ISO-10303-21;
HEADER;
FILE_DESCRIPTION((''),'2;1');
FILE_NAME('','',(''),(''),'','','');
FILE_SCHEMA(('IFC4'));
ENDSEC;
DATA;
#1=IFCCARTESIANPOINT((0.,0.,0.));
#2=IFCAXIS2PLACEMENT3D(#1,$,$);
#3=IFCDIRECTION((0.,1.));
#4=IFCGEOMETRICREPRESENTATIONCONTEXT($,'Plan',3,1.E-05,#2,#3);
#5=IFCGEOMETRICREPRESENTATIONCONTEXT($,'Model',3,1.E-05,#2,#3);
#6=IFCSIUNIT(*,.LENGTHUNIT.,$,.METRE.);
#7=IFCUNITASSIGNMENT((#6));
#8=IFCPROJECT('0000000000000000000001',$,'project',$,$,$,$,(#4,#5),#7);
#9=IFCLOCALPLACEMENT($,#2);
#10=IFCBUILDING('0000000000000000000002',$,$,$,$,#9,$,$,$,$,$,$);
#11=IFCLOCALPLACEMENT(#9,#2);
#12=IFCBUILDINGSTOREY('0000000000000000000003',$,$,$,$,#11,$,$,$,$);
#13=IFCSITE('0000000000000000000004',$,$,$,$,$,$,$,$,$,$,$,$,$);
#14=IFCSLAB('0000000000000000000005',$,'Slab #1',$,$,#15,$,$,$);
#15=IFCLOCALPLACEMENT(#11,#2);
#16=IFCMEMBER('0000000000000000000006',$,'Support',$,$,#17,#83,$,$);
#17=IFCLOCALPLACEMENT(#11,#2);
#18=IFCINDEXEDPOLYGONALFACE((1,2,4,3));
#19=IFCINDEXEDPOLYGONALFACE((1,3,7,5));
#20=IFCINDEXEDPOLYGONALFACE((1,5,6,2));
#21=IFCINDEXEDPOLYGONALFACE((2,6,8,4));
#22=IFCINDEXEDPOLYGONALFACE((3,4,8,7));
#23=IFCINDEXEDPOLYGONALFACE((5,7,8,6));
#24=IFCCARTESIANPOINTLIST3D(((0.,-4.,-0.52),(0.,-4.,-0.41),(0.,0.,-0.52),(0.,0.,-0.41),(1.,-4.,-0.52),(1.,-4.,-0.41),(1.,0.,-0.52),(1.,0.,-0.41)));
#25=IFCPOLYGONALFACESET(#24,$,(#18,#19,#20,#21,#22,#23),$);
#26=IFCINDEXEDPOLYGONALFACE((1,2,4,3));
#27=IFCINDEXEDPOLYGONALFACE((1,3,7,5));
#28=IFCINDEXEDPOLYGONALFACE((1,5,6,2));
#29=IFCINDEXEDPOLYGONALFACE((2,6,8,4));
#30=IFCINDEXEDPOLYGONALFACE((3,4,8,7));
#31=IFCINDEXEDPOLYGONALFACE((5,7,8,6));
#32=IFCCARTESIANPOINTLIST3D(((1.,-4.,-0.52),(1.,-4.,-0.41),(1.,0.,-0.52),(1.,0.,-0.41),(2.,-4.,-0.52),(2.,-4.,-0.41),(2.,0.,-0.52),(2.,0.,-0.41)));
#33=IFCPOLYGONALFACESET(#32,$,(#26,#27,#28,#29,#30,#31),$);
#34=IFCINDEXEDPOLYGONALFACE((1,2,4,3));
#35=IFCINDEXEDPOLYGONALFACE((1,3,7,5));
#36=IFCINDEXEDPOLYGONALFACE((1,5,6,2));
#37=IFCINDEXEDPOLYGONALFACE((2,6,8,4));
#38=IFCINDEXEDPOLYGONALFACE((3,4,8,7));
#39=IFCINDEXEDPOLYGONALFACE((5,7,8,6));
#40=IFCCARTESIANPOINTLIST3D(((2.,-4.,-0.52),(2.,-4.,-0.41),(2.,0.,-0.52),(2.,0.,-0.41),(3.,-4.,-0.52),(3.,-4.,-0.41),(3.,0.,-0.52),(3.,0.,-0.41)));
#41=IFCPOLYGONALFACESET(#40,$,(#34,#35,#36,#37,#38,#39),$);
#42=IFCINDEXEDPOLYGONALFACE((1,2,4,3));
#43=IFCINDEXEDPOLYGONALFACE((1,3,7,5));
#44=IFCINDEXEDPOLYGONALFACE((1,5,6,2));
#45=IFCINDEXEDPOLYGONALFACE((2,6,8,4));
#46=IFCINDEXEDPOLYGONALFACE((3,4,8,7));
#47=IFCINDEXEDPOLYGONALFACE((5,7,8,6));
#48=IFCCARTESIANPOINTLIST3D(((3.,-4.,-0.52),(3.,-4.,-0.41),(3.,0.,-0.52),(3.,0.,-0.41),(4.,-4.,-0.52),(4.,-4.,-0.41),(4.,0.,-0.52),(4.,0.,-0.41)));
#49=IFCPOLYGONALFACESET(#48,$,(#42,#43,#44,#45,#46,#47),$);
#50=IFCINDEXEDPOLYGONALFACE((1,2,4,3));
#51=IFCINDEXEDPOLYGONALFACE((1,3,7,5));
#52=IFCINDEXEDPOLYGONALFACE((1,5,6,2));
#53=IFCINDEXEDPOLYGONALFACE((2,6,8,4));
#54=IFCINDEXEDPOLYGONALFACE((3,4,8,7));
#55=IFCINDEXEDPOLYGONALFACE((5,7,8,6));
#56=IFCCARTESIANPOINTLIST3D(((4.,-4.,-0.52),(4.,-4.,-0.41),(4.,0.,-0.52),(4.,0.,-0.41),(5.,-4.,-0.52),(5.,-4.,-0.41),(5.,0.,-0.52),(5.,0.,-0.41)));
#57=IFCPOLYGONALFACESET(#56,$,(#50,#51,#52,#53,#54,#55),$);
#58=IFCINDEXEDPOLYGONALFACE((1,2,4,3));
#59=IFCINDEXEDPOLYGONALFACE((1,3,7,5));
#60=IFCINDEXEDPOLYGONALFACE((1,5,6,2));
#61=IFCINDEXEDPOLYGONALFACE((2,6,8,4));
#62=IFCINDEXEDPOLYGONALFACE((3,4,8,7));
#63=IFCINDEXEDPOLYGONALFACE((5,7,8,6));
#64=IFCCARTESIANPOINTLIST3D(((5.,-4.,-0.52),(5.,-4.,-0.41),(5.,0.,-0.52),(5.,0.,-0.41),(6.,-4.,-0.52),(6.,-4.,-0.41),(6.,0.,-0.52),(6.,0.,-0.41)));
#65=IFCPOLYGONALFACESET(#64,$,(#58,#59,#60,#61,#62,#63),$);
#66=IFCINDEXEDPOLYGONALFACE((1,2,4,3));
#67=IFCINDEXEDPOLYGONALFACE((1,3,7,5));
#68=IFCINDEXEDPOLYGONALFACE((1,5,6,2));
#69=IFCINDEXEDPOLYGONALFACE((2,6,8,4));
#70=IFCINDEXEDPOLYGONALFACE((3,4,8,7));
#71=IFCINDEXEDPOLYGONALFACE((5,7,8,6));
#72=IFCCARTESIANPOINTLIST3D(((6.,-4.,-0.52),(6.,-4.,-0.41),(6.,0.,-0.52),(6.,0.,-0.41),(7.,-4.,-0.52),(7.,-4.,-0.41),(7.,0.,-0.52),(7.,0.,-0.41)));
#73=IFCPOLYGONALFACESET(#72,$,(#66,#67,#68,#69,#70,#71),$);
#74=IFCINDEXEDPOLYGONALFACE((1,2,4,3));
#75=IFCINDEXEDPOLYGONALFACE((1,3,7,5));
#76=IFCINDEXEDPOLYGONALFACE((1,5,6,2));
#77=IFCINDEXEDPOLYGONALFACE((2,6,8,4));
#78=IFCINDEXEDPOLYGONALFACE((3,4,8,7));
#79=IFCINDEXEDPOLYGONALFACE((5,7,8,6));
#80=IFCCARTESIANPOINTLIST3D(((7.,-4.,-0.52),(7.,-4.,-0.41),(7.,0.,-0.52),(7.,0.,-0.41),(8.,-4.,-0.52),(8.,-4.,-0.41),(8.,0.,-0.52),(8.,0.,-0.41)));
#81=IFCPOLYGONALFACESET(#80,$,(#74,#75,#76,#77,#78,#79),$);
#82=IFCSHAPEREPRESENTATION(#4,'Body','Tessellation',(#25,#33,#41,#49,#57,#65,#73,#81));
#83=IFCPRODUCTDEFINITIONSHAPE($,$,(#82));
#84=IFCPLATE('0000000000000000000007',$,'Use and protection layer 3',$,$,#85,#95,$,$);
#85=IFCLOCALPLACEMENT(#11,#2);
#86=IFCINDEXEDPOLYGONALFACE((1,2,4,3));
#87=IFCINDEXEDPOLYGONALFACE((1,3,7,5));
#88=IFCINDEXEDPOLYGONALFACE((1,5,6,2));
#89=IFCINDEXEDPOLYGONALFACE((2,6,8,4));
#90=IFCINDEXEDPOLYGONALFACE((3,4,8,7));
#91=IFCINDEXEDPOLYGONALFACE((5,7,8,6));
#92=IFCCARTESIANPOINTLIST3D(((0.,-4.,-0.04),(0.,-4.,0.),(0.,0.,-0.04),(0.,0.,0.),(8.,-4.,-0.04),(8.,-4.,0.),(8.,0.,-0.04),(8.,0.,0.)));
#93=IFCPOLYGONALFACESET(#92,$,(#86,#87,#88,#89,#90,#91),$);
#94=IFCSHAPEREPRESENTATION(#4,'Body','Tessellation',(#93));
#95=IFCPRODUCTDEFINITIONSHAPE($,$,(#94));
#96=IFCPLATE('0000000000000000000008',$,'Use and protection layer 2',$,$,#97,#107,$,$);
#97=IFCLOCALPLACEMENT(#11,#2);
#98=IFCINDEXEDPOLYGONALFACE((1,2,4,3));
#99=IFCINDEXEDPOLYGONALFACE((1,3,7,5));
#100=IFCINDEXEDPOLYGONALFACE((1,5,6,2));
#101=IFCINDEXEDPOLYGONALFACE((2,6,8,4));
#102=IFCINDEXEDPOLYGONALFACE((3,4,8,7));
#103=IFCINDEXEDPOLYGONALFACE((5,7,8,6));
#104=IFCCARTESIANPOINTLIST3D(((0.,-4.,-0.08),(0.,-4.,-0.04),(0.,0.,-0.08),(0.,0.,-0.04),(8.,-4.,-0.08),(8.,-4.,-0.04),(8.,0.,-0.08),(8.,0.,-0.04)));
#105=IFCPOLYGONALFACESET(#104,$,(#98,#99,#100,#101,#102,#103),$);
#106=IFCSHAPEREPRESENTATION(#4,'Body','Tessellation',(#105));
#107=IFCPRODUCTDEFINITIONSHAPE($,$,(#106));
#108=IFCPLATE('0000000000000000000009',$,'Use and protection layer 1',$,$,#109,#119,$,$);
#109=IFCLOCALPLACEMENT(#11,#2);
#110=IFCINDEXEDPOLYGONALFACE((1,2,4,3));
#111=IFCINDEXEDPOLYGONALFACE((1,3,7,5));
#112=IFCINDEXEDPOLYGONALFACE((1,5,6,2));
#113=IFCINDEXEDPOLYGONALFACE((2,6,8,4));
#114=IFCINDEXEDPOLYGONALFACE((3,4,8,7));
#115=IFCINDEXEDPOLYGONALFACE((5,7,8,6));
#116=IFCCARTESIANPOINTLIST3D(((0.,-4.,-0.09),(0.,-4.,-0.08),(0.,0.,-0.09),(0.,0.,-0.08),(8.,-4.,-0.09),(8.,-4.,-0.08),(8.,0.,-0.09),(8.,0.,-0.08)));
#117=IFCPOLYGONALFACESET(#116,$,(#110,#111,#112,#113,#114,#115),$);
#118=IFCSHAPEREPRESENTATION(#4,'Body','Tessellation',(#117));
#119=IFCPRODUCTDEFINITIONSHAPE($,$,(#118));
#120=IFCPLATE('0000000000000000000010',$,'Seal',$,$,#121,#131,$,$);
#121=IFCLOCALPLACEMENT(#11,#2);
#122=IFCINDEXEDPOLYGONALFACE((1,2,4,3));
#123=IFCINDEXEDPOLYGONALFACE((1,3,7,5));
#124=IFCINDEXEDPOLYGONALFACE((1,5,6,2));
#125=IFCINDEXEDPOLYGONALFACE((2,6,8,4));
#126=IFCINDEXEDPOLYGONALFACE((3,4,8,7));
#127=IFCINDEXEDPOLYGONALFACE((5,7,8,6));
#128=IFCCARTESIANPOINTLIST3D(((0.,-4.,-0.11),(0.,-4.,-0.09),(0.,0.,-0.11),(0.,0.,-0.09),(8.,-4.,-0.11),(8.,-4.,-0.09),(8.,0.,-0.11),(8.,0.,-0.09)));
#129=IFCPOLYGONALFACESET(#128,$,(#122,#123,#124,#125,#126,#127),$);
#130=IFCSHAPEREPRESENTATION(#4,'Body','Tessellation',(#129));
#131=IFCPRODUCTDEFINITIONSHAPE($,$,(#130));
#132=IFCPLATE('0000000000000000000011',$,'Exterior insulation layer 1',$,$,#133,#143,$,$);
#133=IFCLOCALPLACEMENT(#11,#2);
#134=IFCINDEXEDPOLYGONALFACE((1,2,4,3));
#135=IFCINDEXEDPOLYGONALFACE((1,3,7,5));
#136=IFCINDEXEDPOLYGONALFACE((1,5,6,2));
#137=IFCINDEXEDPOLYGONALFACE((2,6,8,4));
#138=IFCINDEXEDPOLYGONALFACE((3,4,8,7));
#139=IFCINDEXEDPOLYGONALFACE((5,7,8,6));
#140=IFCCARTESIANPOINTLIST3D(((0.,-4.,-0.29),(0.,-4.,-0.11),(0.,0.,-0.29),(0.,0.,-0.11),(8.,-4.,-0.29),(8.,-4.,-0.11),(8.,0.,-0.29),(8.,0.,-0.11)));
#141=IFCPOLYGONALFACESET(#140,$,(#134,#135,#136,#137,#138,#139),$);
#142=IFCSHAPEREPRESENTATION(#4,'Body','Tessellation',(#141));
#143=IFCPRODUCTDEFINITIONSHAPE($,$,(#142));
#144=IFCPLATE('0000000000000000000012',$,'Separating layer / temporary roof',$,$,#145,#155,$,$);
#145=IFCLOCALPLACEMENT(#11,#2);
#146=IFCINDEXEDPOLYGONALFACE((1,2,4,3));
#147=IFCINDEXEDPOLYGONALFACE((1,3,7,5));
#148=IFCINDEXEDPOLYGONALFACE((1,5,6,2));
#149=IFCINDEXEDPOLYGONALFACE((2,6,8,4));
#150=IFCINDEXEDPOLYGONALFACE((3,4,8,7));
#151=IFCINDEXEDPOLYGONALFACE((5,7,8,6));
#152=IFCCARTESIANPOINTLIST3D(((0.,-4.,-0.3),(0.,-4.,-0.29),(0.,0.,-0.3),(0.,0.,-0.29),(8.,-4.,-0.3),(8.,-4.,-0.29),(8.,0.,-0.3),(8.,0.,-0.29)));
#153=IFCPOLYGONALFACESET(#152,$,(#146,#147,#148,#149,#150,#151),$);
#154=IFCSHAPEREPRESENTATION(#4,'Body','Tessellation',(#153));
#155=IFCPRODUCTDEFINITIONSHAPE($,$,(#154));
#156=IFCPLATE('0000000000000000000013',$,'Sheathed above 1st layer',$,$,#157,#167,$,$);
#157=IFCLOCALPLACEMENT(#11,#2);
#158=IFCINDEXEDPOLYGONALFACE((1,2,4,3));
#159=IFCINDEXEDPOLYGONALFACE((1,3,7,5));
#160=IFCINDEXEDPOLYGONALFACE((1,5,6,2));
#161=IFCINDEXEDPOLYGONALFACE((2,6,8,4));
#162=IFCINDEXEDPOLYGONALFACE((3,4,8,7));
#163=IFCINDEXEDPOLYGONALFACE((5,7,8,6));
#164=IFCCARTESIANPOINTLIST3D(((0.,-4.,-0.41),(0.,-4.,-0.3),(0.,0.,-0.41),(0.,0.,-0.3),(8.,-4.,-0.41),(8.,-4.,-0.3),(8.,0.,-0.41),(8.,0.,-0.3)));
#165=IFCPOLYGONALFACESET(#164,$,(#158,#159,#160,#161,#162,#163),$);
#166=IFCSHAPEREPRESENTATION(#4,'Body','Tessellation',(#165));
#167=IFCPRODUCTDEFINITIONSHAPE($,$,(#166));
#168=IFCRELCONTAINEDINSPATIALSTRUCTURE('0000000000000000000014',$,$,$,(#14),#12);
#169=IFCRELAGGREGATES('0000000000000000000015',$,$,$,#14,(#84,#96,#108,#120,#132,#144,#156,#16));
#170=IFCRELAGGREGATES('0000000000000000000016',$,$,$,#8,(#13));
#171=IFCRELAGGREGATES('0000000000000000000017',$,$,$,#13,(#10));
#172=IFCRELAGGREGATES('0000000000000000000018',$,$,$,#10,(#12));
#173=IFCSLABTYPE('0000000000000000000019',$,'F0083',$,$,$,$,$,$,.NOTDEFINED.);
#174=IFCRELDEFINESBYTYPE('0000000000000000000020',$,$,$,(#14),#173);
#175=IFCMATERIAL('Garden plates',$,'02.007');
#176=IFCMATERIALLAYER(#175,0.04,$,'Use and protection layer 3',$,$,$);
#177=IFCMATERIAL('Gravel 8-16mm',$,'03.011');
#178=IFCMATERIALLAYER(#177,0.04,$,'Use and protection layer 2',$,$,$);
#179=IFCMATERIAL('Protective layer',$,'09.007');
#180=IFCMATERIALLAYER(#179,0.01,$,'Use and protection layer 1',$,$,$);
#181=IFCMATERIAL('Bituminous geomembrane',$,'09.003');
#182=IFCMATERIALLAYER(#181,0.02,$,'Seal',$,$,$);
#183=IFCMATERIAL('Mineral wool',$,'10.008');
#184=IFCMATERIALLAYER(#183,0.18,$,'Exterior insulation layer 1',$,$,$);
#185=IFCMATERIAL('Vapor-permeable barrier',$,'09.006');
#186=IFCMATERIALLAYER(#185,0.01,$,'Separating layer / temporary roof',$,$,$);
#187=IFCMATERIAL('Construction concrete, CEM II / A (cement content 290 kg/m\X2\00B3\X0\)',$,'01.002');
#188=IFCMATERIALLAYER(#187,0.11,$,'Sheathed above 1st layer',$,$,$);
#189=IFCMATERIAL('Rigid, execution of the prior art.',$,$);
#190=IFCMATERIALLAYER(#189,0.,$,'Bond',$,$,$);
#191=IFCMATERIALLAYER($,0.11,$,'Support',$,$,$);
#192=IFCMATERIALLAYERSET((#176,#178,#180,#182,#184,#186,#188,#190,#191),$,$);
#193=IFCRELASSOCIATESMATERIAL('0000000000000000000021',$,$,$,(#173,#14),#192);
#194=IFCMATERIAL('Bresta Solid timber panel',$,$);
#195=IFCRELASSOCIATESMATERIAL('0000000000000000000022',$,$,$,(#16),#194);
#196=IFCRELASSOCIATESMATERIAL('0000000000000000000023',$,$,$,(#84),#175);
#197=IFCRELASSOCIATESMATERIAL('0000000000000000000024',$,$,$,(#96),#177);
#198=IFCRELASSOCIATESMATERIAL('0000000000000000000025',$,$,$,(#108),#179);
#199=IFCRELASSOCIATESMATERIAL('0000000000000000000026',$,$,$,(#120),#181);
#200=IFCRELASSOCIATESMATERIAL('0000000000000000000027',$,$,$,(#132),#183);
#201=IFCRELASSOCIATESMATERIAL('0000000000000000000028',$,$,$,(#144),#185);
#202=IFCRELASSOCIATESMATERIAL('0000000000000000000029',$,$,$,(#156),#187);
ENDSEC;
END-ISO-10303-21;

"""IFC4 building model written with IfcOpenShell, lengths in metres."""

from ifc_helpers import new_model, si_unit, direction, frame, frame_2d, origin, origin_with_axes, place, context, project, spatial, rectangle, extrude, material, layer, layer_set, type_object, element, aggregate, save


model = new_model("IFC4")

# Units and contexts
plan_context = context("Plan", 3, precision=1e-05, world=origin(), true_north=direction((0.0, 1.0)))
model_context = context("Model", 3, precision=1e-05, world=origin(), true_north=direction((0.0, 1.0)))
ifc_project = project(units=[si_unit("LENGTHUNIT", "METRE")], contexts=[plan_context, model_context])

# Site, building, storey
site = spatial("IfcSite", under=ifc_project)
building_placement = place(None, origin())
building = spatial("IfcBuilding", under=site, at=building_placement)
storey_placement = place(building_placement, origin())
storey = spatial("IfcBuildingStorey", under=building, at=storey_placement)

# Slab, member, plates
ifc_material_1 = material(Name="Garden plates", Category="02.007")
ifc_layer_1 = layer(ifc_material_1, 0.04, Name="Use and protection layer 3")
ifc_material_2 = material(Name="Gravel 8-16mm", Category="03.011")
ifc_layer_2 = layer(ifc_material_2, 0.04, Name="Use and protection layer 2")
ifc_material_3 = material(Name="Protective layer", Category="09.007")
ifc_layer_3 = layer(ifc_material_3, 0.01, Name="Use and protection layer 1")
ifc_material_4 = material(Name="Bituminous geomembrane", Category="09.003")
ifc_layer_4 = layer(ifc_material_4, 0.02, Name="Seal")
ifc_material_5 = material(Name="Mineral wool", Category="10.008")
ifc_layer_5 = layer(ifc_material_5, 0.18, Name="Exterior insulation layer 1")
ifc_material_6 = material(Name="Vapor-permeable barrier", Category="09.006")
ifc_layer_6 = layer(ifc_material_6, 0.01, Name="Separating layer / temporary roof")
ifc_material_7 = material(Name="Construction concrete, CEM II / A (cement content 290 kg/m³)", Category="01.002")
ifc_layer_7 = layer(ifc_material_7, 0.11, Name="Sheathed above 1st layer")
ifc_material_8 = material(Name="Rigid, execution of the prior art.")
ifc_layer_8 = layer(ifc_material_8, 0.0, Name="Bond")
ifc_layer_9 = layer(None, 0.11, Name="Support")
ifc_layer_set = layer_set([ifc_layer_1, ifc_layer_2, ifc_layer_3, ifc_layer_4, ifc_layer_5, ifc_layer_6, ifc_layer_7, ifc_layer_8, ifc_layer_9])
slab_type = type_object("IfcSlabType", Name="F0083", PredefinedType="NOTDEFINED", material=ifc_layer_set)
slab_placement = place(None, frame((0.0, 0.0, 0.0), z_axis=(0.0, 0.0, -1.0), x_axis=(1.0, 0.0, 0.0)))
slab = element("IfcSlab", 1, at=slab_placement, inside=storey, type_object=slab_type, material=ifc_layer_set, Name="Slab #1")
ifc_material_9 = material(Name="Bresta Solid timber panel")
member_placement = place(slab_placement, origin())
member = element("IfcMember", 2, at=member_placement, material=ifc_material_9, Name="Support", context=plan_context, shape_type="SweptSolid", body=[
    extrude(rectangle(XDim=1.0, YDim=0.11, at=frame_2d((0.5, 0.055), x_axis=(1.0, 0.0))), frame((0.0, 4.0, 0.41), z_axis=(0.0, -1.0, 0.0), x_axis=(1.0, 0.0, 0.0)), (0.0, 0.0, 1.0), 4.0),
    extrude(rectangle(XDim=1.0, YDim=0.11, at=frame_2d((0.5, 0.055), x_axis=(1.0, 0.0))), frame((1.0, 4.0, 0.41), z_axis=(0.0, -1.0, 0.0), x_axis=(1.0, 0.0, 0.0)), (0.0, 0.0, 1.0), 4.0),
    extrude(rectangle(XDim=1.0, YDim=0.11, at=frame_2d((0.5, 0.055), x_axis=(1.0, 0.0))), frame((2.0, 4.0, 0.41), z_axis=(0.0, -1.0, 0.0), x_axis=(1.0, 0.0, 0.0)), (0.0, 0.0, 1.0), 4.0),
    extrude(rectangle(XDim=1.0, YDim=0.11, at=frame_2d((0.5, 0.055), x_axis=(1.0, 0.0))), frame((3.0, 4.0, 0.41), z_axis=(0.0, -1.0, 0.0), x_axis=(1.0, 0.0, 0.0)), (0.0, 0.0, 1.0), 4.0),
    extrude(rectangle(XDim=1.0, YDim=0.11, at=frame_2d((0.5, 0.055), x_axis=(1.0, 0.0))), frame((4.0, 4.0, 0.41), z_axis=(0.0, -1.0, 0.0), x_axis=(1.0, 0.0, 0.0)), (0.0, 0.0, 1.0), 4.0),
    extrude(rectangle(XDim=1.0, YDim=0.11, at=frame_2d((0.5, 0.055), x_axis=(1.0, 0.0))), frame((5.0, 4.0, 0.41), z_axis=(0.0, -1.0, 0.0), x_axis=(1.0, 0.0, 0.0)), (0.0, 0.0, 1.0), 4.0),
    extrude(rectangle(XDim=1.0, YDim=0.11, at=frame_2d((0.5, 0.055), x_axis=(1.0, 0.0))), frame((6.0, 4.0, 0.41), z_axis=(0.0, -1.0, 0.0), x_axis=(1.0, 0.0, 0.0)), (0.0, 0.0, 1.0), 4.0),
    extrude(rectangle(XDim=1.0, YDim=0.11, at=frame_2d((0.5, 0.055), x_axis=(1.0, 0.0))), frame((7.0, 4.0, 0.41), z_axis=(0.0, -1.0, 0.0), x_axis=(1.0, 0.0, 0.0)), (0.0, 0.0, 1.0), 4.0),
])
plate_1_placement = place(slab_placement, origin())
plate_1 = element("IfcPlate", 3, at=plate_1_placement, material=ifc_material_1, Name="Use and protection layer 3", context=plan_context, shape_type="SweptSolid", body=[
    extrude(rectangle(XDim=8.0, YDim=4.0, at=frame_2d((4.0, 2.0), x_axis=(1.0, 0.0))), origin_with_axes(), (0.0, 0.0, 1.0), 0.04),
])
plate_2_placement = place(slab_placement, origin())
plate_2 = element("IfcPlate", 4, at=plate_2_placement, material=ifc_material_2, Name="Use and protection layer 2", context=plan_context, shape_type="SweptSolid", body=[
    extrude(rectangle(XDim=8.0, YDim=4.0, at=frame_2d((4.0, 2.0), x_axis=(1.0, 0.0))), frame((0.0, 0.0, 0.04), z_axis=(0.0, 0.0, 1.0), x_axis=(1.0, 0.0, 0.0)), (0.0, 0.0, 1.0), 0.04),
])
plate_3_placement = place(slab_placement, origin())
plate_3 = element("IfcPlate", 5, at=plate_3_placement, material=ifc_material_3, Name="Use and protection layer 1", context=plan_context, shape_type="SweptSolid", body=[
    extrude(rectangle(XDim=8.0, YDim=4.0, at=frame_2d((4.0, 2.0), x_axis=(1.0, 0.0))), frame((0.0, 0.0, 0.08), z_axis=(0.0, 0.0, 1.0), x_axis=(1.0, 0.0, 0.0)), (0.0, 0.0, 1.0), 0.01),
])
plate_4_placement = place(slab_placement, origin())
plate_4 = element("IfcPlate", 6, at=plate_4_placement, material=ifc_material_4, Name="Seal", context=plan_context, shape_type="SweptSolid", body=[
    extrude(rectangle(XDim=8.0, YDim=4.0, at=frame_2d((4.0, 2.0), x_axis=(1.0, 0.0))), frame((0.0, 0.0, 0.09), z_axis=(0.0, 0.0, 1.0), x_axis=(1.0, 0.0, 0.0)), (0.0, 0.0, 1.0), 0.02),
])
plate_5_placement = place(slab_placement, origin())
plate_5 = element("IfcPlate", 7, at=plate_5_placement, material=ifc_material_5, Name="Exterior insulation layer 1", context=plan_context, shape_type="SweptSolid", body=[
    extrude(rectangle(XDim=8.0, YDim=4.0, at=frame_2d((4.0, 2.0), x_axis=(1.0, 0.0))), frame((0.0, 0.0, 0.11), z_axis=(0.0, 0.0, 1.0), x_axis=(1.0, 0.0, 0.0)), (0.0, 0.0, 1.0), 0.18),
])
plate_6_placement = place(slab_placement, origin())
plate_6 = element("IfcPlate", 8, at=plate_6_placement, material=ifc_material_6, Name="Separating layer / temporary roof", context=plan_context, shape_type="SweptSolid", body=[
    extrude(rectangle(XDim=8.0, YDim=4.0, at=frame_2d((4.0, 2.0), x_axis=(1.0, 0.0))), frame((0.0, 0.0, 0.29), z_axis=(0.0, 0.0, 1.0), x_axis=(1.0, 0.0, 0.0)), (0.0, 0.0, 1.0), 0.01),
])
plate_7_placement = place(slab_placement, origin())
plate_7 = element("IfcPlate", 9, at=plate_7_placement, material=ifc_material_7, Name="Sheathed above 1st layer", context=plan_context, shape_type="SweptSolid", body=[
    extrude(rectangle(XDim=8.0, YDim=4.0, at=frame_2d((4.0, 2.0), x_axis=(1.0, 0.0))), frame((0.0, 0.0, 0.3), z_axis=(0.0, 0.0, 1.0), x_axis=(1.0, 0.0, 0.0)), (0.0, 0.0, 1.0), 0.11),
])
aggregate(slab, [plate_1, plate_2, plate_3, plate_4, plate_5, plate_6, plate_7, member])

save(model, "model.ifc")
